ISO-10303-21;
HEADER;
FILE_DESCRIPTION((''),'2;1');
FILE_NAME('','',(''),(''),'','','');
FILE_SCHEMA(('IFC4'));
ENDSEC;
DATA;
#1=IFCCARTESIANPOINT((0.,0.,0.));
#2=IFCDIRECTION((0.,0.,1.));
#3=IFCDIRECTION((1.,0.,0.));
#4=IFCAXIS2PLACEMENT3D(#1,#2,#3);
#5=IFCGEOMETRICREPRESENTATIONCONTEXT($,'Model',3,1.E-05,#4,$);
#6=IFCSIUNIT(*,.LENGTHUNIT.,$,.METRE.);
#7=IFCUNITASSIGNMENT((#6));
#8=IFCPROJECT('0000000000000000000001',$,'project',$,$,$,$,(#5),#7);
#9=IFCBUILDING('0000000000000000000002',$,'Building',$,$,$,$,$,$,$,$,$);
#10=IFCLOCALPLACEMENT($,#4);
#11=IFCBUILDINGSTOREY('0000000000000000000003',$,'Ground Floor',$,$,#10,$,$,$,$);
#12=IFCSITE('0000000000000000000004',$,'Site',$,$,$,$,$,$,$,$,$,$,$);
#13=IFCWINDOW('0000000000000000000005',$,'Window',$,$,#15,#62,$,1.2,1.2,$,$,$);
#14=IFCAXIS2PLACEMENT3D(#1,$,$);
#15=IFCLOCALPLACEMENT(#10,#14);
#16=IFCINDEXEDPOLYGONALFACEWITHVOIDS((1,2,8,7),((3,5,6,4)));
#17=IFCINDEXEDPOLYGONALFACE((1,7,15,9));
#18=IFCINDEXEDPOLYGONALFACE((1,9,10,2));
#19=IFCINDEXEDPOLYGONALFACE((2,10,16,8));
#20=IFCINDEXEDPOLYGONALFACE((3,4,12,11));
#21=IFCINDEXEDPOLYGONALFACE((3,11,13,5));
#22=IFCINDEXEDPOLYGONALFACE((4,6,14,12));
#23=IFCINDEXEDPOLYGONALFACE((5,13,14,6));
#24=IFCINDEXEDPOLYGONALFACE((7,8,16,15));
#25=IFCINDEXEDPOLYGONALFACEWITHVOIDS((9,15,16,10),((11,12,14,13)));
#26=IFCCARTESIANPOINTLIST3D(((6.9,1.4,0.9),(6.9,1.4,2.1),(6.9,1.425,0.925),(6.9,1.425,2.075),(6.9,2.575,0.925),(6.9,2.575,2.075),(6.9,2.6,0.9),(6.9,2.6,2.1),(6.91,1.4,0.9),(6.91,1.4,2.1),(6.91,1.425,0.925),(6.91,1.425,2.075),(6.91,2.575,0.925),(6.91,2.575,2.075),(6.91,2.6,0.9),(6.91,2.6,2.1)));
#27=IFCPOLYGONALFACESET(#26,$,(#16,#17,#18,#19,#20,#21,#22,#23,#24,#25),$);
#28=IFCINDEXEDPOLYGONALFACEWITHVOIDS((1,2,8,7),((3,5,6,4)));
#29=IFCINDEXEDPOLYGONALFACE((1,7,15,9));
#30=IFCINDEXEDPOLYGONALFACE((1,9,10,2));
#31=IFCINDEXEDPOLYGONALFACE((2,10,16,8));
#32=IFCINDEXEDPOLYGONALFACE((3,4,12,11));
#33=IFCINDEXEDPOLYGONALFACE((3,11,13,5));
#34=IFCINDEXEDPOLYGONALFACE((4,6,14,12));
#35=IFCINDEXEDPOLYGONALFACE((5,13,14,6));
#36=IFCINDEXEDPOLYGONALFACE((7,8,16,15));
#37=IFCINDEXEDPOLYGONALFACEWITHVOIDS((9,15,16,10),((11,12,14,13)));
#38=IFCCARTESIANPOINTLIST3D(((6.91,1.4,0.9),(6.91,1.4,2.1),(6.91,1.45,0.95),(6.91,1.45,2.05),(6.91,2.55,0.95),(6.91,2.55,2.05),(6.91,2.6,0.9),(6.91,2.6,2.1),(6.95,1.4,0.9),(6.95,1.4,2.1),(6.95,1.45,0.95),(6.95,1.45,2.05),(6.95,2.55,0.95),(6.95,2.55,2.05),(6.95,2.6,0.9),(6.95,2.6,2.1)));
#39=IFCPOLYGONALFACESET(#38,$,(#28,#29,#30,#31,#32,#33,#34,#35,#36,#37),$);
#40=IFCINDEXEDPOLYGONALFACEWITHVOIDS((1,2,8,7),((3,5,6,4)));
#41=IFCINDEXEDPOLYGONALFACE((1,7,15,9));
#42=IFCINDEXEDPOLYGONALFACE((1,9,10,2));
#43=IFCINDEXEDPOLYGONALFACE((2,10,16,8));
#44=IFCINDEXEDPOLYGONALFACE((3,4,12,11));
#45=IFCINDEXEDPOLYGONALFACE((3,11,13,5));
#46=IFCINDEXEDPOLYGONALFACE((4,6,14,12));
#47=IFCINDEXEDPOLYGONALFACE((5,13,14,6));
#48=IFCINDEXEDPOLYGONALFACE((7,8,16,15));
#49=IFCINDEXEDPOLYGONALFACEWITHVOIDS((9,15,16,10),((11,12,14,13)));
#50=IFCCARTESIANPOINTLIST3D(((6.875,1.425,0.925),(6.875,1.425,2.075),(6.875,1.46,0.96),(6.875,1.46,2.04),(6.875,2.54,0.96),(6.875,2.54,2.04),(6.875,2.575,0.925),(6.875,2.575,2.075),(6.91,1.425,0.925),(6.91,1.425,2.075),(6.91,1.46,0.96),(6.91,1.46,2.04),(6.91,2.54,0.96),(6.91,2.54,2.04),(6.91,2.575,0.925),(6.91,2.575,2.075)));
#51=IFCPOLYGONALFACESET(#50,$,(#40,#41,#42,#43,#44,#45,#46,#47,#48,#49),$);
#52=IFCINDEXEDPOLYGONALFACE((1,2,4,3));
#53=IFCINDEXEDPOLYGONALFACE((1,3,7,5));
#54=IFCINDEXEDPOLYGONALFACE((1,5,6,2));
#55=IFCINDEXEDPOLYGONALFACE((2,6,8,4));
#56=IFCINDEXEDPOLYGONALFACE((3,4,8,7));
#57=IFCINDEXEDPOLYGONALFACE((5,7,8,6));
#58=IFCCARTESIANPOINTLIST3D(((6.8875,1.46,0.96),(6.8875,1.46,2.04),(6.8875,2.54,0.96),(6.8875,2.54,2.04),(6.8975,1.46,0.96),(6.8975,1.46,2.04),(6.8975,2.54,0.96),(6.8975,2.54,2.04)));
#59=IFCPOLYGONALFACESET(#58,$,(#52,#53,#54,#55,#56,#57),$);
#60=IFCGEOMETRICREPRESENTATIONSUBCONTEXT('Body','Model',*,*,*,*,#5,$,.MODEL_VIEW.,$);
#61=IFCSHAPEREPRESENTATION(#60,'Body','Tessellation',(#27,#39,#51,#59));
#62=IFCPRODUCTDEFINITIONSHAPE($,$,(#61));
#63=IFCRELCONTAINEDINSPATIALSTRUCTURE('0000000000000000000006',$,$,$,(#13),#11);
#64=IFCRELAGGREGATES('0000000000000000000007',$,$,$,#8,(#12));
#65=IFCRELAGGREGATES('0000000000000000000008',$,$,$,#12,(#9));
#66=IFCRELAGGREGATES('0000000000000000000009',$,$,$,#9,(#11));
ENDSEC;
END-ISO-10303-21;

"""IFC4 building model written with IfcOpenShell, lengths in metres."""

from ifc_helpers import new_model, si_unit, frame, origin_with_axes, place, context, subcontext, project, spatial, line, indexed_curve, outline, extrude, element, save


model = new_model("IFC4")

# Units and contexts
model_context = context("Model", 3, precision=1e-05, world=origin_with_axes())
body_context = subcontext(model_context, "Body", "Model", "MODEL_VIEW")
ifc_project = project(units=[si_unit("LENGTHUNIT", "METRE")], contexts=[model_context])

# Site, building, storey
site = spatial("IfcSite", under=ifc_project, Name="Site")
building = spatial("IfcBuilding", under=site, Name="Building")
storey_placement = place(None, origin_with_axes())
storey = spatial("IfcBuildingStorey", under=building, at=storey_placement, Name="Ground Floor")

# Window
window_1_placement = place(storey_placement, frame((7.0, 1.4, 0.9), z_axis=(0.0, 0.0, 1.0), x_axis=(0.0, 1.0, 0.0)))
element("IfcWindow", 1, at=window_1_placement, inside=storey, Name="Window", OverallHeight=1.2, OverallWidth=1.2, context=body_context, shape_type="SweptSolid", body=[
    extrude(outline(indexed_curve([(0.0, 0.0), (1.2, 0.0), (1.2, 1.2), (0.0, 1.2)], segments=[line(1, 2, 3, 4, 1)]), holes=[indexed_curve([(0.025, 0.025), (1.175, 0.025), (1.175, 1.175), (0.025, 1.175)], segments=[line(1, 2, 3, 4, 1)])]), frame((0.0, 0.09, 0.0), z_axis=(0.0, -1.0, 0.0), x_axis=(1.0, 0.0, 0.0)), (0.0, 0.0, -1.0), 0.01),
    extrude(outline(indexed_curve([(0.0, 0.0), (1.2, 0.0), (1.2, 1.2), (0.0, 1.2)], segments=[line(1, 2, 3, 4, 1)]), holes=[indexed_curve([(0.05, 0.05), (1.15, 0.05), (1.15, 1.15), (0.05, 1.15)], segments=[line(1, 2, 3, 4, 1)])]), frame((0.0, 0.05, 0.0), z_axis=(0.0, -1.0, 0.0), x_axis=(1.0, 0.0, 0.0)), (0.0, 0.0, -1.0), 0.04),
    extrude(outline(indexed_curve([(0.0, 0.0), (1.15, 0.0), (1.15, 1.15), (0.0, 1.15)], segments=[line(1, 2, 3, 4, 1)]), holes=[indexed_curve([(0.035, 0.035), (1.115, 0.035), (1.115, 1.115), (0.035, 1.115)], segments=[line(1, 2, 3, 4, 1)])]), frame((0.025, 0.09, 0.025), z_axis=(0.0, -1.0, 0.0), x_axis=(1.0, 0.0, 0.0)), (0.0, 0.0, -1.0), 0.035),
    extrude(outline(indexed_curve([(0.035, 0.035), (1.115, 0.035), (1.115, 1.115), (0.035, 1.115)], segments=[line(1, 2, 3, 4, 1)])), frame((0.025, 0.1025, 0.025), z_axis=(0.0, -1.0, 0.0), x_axis=(1.0, 0.0, 0.0)), (0.0, 0.0, -1.0), 0.01),
])

save(model, "model.ifc")
